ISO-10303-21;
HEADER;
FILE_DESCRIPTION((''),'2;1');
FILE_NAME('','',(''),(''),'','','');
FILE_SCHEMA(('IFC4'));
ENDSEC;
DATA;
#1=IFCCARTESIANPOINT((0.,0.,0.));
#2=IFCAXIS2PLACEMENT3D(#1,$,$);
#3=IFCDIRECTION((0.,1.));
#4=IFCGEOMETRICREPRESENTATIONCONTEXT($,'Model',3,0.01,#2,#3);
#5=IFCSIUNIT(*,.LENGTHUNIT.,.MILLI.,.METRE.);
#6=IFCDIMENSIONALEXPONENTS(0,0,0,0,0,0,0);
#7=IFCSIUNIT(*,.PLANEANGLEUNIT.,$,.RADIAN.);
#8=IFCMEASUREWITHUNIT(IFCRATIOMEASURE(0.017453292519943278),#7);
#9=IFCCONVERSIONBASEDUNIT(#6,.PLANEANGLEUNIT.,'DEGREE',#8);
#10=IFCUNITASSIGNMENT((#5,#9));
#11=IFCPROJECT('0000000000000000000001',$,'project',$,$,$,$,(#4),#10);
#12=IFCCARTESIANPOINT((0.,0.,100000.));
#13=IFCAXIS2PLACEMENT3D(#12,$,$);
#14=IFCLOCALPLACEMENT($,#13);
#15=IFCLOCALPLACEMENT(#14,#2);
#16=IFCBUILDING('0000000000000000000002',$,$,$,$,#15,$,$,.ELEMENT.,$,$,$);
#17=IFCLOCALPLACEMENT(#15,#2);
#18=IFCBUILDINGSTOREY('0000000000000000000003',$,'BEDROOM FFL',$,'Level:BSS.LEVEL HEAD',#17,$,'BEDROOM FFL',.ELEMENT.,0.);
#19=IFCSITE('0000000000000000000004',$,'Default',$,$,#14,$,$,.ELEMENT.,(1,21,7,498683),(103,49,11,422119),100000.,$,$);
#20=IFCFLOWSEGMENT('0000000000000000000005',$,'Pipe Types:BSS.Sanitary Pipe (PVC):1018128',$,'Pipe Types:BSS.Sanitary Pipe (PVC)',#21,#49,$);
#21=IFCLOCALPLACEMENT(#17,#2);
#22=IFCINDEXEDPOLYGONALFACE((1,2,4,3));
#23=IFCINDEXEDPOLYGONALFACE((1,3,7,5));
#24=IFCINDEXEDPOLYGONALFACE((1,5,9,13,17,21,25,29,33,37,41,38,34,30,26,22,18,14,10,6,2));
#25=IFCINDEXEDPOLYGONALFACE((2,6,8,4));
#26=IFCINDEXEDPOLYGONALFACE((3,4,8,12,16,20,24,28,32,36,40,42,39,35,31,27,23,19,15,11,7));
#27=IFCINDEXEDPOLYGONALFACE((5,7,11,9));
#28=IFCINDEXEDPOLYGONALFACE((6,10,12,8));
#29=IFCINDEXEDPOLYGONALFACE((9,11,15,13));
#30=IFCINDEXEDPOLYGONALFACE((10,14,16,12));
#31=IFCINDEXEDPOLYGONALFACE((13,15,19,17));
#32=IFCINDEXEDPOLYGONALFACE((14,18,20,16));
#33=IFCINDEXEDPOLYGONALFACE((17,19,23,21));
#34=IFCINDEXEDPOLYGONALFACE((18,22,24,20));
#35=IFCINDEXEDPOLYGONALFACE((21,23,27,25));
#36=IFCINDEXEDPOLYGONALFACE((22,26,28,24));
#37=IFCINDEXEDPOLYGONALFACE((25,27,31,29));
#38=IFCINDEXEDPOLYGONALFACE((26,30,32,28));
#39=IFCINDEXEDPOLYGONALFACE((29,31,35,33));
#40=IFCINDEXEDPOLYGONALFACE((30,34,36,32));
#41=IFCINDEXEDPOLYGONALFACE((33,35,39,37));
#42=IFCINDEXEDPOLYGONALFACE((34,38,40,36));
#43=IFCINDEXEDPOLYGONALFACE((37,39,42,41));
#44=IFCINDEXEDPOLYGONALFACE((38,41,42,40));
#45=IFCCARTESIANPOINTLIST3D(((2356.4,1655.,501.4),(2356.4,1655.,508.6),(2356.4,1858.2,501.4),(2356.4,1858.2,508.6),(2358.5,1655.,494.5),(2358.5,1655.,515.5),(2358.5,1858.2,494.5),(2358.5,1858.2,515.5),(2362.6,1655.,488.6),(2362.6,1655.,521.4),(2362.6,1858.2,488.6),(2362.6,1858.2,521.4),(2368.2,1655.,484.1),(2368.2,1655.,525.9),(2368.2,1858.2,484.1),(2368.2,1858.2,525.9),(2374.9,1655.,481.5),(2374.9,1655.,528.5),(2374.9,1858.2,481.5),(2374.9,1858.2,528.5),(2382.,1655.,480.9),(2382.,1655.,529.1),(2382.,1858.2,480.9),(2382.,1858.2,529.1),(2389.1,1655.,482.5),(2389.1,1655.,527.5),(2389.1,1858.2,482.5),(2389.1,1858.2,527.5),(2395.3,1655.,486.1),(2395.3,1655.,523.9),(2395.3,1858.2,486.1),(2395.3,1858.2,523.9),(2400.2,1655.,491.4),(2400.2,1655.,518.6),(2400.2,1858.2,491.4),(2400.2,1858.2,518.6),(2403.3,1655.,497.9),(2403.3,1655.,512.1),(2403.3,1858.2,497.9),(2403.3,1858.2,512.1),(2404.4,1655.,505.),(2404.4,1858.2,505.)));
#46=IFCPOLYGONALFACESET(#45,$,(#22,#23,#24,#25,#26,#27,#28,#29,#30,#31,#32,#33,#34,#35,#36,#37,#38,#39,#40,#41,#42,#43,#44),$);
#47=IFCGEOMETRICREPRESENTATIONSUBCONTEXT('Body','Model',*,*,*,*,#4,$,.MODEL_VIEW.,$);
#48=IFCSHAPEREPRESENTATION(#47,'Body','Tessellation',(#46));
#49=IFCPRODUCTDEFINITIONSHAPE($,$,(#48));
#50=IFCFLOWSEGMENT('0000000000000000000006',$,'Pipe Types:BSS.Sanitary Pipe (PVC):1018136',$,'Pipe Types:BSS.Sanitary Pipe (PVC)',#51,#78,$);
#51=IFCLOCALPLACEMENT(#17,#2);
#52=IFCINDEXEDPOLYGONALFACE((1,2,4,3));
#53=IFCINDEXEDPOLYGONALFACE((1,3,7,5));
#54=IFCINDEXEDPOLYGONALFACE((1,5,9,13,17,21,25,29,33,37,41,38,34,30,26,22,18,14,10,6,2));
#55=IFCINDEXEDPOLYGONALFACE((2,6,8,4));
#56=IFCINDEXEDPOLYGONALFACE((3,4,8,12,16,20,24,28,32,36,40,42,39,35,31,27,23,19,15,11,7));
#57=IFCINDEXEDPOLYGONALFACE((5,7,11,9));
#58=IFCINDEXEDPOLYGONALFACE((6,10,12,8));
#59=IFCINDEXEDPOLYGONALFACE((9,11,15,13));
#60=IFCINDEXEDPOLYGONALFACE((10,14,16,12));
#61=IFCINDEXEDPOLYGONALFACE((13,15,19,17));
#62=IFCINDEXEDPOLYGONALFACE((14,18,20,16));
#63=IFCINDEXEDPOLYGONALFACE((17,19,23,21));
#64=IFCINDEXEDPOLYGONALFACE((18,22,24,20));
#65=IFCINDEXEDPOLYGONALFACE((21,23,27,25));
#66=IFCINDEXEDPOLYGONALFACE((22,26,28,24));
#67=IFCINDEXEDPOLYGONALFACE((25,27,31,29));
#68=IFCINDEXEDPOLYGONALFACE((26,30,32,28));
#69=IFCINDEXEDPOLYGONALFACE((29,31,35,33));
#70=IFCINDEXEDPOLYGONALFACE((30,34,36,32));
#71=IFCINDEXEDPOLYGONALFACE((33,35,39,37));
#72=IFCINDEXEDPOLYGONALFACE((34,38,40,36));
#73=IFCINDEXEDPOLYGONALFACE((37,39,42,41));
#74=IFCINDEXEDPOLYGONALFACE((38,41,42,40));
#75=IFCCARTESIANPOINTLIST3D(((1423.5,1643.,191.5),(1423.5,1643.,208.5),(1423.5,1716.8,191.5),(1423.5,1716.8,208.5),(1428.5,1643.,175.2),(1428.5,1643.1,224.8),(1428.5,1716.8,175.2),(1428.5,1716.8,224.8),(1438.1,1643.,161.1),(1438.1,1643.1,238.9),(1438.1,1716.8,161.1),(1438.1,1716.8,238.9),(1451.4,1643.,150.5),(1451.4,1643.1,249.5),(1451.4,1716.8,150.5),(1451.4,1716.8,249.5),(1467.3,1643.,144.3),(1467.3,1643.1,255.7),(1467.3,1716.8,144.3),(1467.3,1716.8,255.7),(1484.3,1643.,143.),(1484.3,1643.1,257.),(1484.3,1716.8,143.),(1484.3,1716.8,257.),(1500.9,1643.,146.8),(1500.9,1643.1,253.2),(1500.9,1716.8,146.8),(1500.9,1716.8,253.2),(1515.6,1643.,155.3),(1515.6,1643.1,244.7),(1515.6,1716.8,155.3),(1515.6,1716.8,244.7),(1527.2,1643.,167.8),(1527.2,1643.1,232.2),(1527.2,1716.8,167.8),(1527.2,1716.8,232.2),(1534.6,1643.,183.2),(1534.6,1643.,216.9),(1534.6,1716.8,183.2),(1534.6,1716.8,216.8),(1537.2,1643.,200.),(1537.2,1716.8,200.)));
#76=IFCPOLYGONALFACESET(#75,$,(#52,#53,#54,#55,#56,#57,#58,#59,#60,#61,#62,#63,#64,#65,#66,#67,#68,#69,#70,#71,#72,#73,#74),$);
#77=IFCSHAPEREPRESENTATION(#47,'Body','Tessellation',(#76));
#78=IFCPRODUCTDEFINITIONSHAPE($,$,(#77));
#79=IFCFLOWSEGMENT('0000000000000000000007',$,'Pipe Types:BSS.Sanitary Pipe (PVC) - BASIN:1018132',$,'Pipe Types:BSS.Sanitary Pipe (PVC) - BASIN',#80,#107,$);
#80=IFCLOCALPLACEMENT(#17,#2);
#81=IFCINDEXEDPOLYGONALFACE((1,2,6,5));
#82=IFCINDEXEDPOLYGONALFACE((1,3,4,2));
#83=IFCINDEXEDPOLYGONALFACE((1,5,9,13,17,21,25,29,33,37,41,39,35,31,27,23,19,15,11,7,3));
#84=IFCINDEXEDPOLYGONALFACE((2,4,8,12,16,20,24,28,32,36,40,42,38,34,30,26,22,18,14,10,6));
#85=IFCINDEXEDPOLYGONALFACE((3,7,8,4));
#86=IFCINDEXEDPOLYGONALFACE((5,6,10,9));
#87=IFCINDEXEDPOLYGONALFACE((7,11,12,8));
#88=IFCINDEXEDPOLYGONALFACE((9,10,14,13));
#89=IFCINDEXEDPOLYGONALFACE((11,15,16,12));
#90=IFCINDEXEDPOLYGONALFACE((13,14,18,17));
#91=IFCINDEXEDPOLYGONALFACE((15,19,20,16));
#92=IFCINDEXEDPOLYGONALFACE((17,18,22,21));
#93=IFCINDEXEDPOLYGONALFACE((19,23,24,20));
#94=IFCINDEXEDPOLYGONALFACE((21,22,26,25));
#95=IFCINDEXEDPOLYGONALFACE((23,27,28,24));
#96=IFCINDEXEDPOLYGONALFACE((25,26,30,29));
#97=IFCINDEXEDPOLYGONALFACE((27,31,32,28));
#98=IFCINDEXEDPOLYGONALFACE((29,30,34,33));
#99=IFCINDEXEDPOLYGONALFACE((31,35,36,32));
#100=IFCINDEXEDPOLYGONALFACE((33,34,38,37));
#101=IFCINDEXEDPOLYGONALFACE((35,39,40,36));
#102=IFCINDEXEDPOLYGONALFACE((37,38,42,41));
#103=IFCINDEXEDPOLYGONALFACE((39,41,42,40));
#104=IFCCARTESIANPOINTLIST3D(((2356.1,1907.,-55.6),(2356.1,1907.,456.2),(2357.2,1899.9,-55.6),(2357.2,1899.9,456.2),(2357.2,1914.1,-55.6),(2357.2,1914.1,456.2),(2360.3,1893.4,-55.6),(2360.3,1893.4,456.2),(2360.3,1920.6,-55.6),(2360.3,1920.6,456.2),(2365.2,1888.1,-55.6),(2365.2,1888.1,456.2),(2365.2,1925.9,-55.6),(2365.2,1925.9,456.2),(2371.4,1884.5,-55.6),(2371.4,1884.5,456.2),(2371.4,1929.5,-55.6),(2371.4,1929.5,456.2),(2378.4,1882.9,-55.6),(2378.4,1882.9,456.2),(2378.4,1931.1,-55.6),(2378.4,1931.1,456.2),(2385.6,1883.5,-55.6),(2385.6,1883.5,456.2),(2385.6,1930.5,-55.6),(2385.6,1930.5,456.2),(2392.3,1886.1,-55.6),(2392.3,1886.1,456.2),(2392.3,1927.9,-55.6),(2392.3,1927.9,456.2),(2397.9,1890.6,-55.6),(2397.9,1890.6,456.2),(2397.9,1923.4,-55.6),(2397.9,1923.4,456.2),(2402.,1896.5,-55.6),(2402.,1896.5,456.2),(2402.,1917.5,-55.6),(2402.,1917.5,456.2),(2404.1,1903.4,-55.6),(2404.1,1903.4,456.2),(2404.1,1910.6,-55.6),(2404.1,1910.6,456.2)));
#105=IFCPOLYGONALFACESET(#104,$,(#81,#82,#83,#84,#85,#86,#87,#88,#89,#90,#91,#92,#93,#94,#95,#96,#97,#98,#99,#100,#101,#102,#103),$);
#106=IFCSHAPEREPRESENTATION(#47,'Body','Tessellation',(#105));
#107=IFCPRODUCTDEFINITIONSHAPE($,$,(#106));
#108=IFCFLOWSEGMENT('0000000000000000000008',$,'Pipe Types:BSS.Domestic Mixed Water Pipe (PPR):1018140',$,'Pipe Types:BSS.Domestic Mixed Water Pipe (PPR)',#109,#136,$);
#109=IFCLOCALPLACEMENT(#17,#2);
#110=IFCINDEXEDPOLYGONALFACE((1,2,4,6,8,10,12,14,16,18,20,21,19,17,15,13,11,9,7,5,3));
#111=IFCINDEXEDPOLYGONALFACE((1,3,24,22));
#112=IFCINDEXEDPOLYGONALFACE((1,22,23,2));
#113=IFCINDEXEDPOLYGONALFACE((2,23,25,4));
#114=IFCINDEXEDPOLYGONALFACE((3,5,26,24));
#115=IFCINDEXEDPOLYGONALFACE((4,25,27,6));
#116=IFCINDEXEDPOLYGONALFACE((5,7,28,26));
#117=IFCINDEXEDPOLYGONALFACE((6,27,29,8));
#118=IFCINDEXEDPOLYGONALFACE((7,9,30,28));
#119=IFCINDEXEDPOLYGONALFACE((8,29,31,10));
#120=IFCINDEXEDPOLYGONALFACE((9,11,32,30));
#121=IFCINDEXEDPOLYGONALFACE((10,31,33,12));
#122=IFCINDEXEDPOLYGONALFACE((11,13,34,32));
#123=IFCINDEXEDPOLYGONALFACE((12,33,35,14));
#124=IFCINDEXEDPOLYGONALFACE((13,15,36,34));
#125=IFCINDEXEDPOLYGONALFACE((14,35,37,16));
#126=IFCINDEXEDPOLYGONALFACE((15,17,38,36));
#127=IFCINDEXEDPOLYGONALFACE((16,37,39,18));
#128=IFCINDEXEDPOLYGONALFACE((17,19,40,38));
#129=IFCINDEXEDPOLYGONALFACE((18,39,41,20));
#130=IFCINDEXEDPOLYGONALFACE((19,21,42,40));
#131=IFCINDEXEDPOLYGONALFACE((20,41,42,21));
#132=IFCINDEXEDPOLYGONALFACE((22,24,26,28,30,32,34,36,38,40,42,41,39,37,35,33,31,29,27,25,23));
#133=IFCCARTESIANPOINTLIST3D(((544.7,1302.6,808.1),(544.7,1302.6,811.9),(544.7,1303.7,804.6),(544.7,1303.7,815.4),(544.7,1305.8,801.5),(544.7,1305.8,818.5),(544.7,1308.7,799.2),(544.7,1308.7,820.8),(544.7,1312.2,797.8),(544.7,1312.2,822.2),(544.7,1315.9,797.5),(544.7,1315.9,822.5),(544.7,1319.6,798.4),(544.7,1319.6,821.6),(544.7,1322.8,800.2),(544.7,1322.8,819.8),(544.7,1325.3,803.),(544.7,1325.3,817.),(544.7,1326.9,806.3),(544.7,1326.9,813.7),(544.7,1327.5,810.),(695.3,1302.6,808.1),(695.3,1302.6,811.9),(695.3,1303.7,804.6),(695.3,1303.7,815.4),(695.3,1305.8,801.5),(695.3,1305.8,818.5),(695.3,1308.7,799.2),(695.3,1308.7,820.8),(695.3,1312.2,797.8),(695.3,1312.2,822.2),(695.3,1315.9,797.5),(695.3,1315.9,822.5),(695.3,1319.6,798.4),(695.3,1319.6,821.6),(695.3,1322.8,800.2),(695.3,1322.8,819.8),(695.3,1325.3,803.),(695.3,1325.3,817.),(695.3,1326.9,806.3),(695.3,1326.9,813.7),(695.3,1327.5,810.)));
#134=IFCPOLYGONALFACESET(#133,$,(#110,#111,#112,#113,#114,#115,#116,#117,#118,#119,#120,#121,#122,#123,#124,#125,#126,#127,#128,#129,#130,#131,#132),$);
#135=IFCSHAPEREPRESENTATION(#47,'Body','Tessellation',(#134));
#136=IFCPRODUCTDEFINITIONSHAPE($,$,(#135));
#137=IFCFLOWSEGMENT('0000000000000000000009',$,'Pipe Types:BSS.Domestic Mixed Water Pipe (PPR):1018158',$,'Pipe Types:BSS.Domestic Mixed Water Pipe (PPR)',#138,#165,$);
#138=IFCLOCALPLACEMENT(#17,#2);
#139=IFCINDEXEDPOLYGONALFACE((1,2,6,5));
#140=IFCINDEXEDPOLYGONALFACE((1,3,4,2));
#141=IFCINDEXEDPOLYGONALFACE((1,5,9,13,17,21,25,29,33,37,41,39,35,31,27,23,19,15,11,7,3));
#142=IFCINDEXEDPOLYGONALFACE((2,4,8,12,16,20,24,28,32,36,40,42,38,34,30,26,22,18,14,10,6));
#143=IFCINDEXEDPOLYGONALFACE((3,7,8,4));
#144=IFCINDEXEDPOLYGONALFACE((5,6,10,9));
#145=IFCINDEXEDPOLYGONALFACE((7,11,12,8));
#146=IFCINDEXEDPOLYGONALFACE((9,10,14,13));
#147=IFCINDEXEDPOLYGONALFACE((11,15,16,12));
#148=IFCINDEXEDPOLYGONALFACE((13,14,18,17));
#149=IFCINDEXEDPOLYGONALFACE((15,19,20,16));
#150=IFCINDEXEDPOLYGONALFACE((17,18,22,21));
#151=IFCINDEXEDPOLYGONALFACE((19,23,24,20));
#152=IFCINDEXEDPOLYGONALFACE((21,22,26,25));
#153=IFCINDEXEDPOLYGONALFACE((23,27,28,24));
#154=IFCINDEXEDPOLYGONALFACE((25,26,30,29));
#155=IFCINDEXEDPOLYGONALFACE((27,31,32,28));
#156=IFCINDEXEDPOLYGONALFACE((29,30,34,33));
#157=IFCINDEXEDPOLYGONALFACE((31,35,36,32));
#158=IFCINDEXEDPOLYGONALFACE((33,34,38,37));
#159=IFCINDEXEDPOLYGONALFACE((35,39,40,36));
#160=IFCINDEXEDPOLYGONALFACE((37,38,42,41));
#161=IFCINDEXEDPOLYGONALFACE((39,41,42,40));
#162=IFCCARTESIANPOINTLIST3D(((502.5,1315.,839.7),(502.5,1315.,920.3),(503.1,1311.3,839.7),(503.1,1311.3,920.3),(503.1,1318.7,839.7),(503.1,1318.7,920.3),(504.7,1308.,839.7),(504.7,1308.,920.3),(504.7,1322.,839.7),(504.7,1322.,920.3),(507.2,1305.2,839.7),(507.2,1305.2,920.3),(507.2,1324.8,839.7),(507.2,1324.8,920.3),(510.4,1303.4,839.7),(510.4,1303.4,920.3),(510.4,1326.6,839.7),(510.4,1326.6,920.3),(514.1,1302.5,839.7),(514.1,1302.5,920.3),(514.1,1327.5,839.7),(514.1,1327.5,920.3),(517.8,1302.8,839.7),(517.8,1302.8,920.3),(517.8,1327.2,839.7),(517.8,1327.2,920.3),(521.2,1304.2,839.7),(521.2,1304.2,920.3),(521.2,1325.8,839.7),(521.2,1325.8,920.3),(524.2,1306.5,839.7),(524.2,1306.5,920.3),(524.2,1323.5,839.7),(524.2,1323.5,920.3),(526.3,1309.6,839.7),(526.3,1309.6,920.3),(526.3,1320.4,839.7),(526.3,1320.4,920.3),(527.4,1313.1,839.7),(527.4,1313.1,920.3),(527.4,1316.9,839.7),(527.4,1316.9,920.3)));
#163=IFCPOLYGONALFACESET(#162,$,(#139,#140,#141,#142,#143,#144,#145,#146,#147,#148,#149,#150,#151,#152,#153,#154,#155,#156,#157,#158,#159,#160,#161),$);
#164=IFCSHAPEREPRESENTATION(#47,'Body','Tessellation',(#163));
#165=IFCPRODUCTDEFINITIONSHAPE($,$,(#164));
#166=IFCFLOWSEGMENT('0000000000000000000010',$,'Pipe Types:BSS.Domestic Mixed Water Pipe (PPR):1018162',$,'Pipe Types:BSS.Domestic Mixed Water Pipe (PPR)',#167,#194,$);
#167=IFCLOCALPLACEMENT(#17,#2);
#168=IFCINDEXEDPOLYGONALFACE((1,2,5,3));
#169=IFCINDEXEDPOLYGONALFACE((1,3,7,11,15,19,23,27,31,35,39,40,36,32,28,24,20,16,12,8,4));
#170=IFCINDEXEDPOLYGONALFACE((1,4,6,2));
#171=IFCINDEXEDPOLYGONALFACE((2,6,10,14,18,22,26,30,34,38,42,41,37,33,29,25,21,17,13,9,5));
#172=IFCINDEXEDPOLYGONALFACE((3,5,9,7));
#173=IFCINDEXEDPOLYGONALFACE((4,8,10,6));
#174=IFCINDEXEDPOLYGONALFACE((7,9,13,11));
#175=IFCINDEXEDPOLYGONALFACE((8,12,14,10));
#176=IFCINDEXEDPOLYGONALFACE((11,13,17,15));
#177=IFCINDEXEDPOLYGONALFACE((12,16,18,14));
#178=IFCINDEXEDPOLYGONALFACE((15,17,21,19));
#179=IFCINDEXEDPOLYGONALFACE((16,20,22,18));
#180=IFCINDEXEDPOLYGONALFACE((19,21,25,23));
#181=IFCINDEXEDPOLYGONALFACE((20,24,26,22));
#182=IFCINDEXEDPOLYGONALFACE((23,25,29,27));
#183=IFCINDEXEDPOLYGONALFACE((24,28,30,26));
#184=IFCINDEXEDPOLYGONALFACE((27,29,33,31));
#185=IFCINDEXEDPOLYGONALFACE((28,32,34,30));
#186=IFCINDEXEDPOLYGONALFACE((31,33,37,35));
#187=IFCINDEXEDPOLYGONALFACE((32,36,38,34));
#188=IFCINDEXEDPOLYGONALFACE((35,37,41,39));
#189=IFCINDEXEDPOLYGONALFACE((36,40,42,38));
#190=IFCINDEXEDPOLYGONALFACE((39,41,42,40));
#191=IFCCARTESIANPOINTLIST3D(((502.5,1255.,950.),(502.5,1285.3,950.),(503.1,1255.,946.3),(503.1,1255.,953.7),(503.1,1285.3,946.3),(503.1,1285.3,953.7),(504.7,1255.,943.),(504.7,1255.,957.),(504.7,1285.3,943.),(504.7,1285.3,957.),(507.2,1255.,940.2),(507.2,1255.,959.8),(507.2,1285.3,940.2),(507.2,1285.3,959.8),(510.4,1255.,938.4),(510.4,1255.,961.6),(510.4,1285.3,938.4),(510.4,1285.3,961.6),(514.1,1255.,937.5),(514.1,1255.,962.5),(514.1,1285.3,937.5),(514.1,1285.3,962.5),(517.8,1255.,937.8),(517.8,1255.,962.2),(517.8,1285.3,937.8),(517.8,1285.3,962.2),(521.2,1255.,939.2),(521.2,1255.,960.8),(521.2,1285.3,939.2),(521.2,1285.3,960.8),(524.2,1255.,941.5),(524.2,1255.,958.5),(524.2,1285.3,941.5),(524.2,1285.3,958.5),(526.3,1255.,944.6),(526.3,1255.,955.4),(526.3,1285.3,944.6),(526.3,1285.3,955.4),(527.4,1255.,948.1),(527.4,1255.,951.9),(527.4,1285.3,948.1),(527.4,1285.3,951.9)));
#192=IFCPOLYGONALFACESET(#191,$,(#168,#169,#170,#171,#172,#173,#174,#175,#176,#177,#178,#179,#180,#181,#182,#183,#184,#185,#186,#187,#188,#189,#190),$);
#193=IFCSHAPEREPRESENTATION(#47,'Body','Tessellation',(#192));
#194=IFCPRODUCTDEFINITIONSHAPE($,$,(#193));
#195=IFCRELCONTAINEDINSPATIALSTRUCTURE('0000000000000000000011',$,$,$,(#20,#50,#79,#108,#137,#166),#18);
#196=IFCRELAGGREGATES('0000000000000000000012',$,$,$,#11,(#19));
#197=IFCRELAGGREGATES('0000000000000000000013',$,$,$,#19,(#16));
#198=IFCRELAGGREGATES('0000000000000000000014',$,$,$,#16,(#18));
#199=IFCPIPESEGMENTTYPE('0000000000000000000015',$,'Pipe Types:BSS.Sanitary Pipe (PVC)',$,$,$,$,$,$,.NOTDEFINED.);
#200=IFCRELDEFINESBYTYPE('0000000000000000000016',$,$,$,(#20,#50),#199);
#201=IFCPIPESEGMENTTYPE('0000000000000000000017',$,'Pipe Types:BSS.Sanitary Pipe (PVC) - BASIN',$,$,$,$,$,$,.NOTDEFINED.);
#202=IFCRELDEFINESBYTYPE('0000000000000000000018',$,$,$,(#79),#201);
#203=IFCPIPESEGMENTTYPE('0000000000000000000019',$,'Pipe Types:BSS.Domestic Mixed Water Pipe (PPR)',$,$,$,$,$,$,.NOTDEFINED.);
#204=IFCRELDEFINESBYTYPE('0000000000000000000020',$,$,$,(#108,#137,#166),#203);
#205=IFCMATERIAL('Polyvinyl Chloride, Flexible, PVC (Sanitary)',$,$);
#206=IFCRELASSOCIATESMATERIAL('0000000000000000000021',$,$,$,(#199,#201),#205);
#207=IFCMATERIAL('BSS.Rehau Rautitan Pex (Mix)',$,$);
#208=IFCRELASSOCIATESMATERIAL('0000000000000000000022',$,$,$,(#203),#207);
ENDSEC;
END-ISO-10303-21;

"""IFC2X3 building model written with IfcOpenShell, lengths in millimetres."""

from ifc_helpers import new_model, entity, si_unit, converted_unit, direction, frame, frame_2d, origin, origin_2d_with_axis, place, context, subcontext, project, spatial, circle, extrude, material, type_object, element, save


model = new_model("IFC2X3")

# Units and contexts
model_context = context("Model", 3, precision=0.01, world=origin(), true_north=direction((0.0, 1.0)))
body_context = subcontext(model_context, "Body", "Model", "MODEL_VIEW")
ifc_project = project(units=[si_unit("LENGTHUNIT", "METRE", prefix="MILLI"), converted_unit("PLANEANGLEUNIT", "DEGREE", entity("IfcRatioMeasure", 0.017453292519943278), si_unit("PLANEANGLEUNIT", "RADIAN"), dimensions=[0, 0, 0, 0, 0, 0, 0])], contexts=[model_context])

# Site, building, storey
site_placement = place(None, frame((0.0, 0.0, 100000.0)))
site = spatial("IfcSite", under=ifc_project, at=site_placement, Name="Default", CompositionType="ELEMENT", RefLatitude=(1, 21, 7, 498683), RefLongitude=(103, 49, 11, 422119), RefElevation=100000.0)
building_placement = place(site_placement, origin())
building = spatial("IfcBuilding", under=site, at=building_placement, CompositionType="ELEMENT")
storey_placement = place(building_placement, origin())
storey = spatial("IfcBuildingStorey", under=building, at=storey_placement, Name="BEDROOM FFL", ObjectType="Level:BSS.LEVEL HEAD", LongName="BEDROOM FFL", CompositionType="ELEMENT", Elevation=0.0)

# Flow segments
ifc_material_1 = material(Name="Polyvinyl Chloride, Flexible, PVC (Sanitary)")
pipe_segment_type_1 = type_object("IfcPipeSegmentType", Name="Pipe Types:BSS.Sanitary Pipe (PVC)", PredefinedType="NOTDEFINED", material=ifc_material_1)
flow_segment_1_placement = place(storey_placement, origin())
element("IfcFlowSegment", 1, at=flow_segment_1_placement, inside=storey, type_object=pipe_segment_type_1, Name="Pipe Types:BSS.Sanitary Pipe (PVC):1018128", ObjectType="Pipe Types:BSS.Sanitary Pipe (PVC)", context=body_context, shape_type="SweptSolid", body=[
    extrude(circle(Radius=24.1, at=origin_2d_with_axis()), frame((2380.2, 1655.0, 505.0), z_axis=(0.0, 1.0, 0.0), x_axis=(1.0, 0.0, 0.0)), (0.0, 0.0, 1.0), 203.2),
])
flow_segment_2_placement = place(storey_placement, origin())
element("IfcFlowSegment", 2, at=flow_segment_2_placement, inside=storey, type_object=pipe_segment_type_1, Name="Pipe Types:BSS.Sanitary Pipe (PVC):1018136", ObjectType="Pipe Types:BSS.Sanitary Pipe (PVC)", context=body_context, shape_type="SweptSolid", body=[
    extrude(circle(Radius=57.2, at=frame_2d((0.0, 0.0), x_axis=(1.0, 0.0))), frame((1480.0, 1716.8, 200.0), z_axis=(0.0, -1.0, 0.000211), x_axis=(1.0, 0.0, 0.0)), (0.0, 0.0, 1.0), 73.8),
])
pipe_segment_type_2 = type_object("IfcPipeSegmentType", Name="Pipe Types:BSS.Sanitary Pipe (PVC) - BASIN", PredefinedType="NOTDEFINED", material=ifc_material_1)
flow_segment_3_placement = place(storey_placement, origin())
element("IfcFlowSegment", 3, at=flow_segment_3_placement, inside=storey, type_object=pipe_segment_type_2, Name="Pipe Types:BSS.Sanitary Pipe (PVC) - BASIN:1018132", ObjectType="Pipe Types:BSS.Sanitary Pipe (PVC) - BASIN", context=body_context, shape_type="SweptSolid", body=[
    extrude(circle(Radius=24.1, at=frame_2d((0.0, 0.0), x_axis=(1.0, 0.0))), frame((2380.2, 1907.0, -55.6), z_axis=(0.0, 0.0, 1.0), x_axis=(-1.0, 0.0, 0.0)), (0.0, 0.0, 1.0), 511.8),
])
ifc_material_2 = material(Name="BSS.Rehau Rautitan Pex (Mix)")
pipe_segment_type_3 = type_object("IfcPipeSegmentType", Name="Pipe Types:BSS.Domestic Mixed Water Pipe (PPR)", PredefinedType="NOTDEFINED", material=ifc_material_2)
flow_segment_4_placement = place(storey_placement, origin())
element("IfcFlowSegment", 4, at=flow_segment_4_placement, inside=storey, type_object=pipe_segment_type_3, Name="Pipe Types:BSS.Domestic Mixed Water Pipe (PPR):1018140", ObjectType="Pipe Types:BSS.Domestic Mixed Water Pipe (PPR)", context=body_context, shape_type="SweptSolid", body=[
    extrude(circle(Radius=12.5, at=frame_2d((0.0, 0.0), x_axis=(1.0, 0.0))), frame((544.7, 1315.0, 810.0), z_axis=(1.0, 0.0, 0.0), x_axis=(0.0, 1.0, 0.0)), (0.0, 0.0, 1.0), 150.6),
])
flow_segment_5_placement = place(storey_placement, origin())
element("IfcFlowSegment", 5, at=flow_segment_5_placement, inside=storey, type_object=pipe_segment_type_3, Name="Pipe Types:BSS.Domestic Mixed Water Pipe (PPR):1018158", ObjectType="Pipe Types:BSS.Domestic Mixed Water Pipe (PPR)", context=body_context, shape_type="SweptSolid", body=[
    extrude(circle(Radius=12.5, at=origin_2d_with_axis()), frame((515.0, 1315.0, 839.7), z_axis=(0.0, 0.0, 1.0), x_axis=(-1.0, 0.0, 0.0)), (0.0, 0.0, 1.0), 80.6),
])
flow_segment_6_placement = place(storey_placement, origin())
element("IfcFlowSegment", 6, at=flow_segment_6_placement, inside=storey, type_object=pipe_segment_type_3, Name="Pipe Types:BSS.Domestic Mixed Water Pipe (PPR):1018162", ObjectType="Pipe Types:BSS.Domestic Mixed Water Pipe (PPR)", context=body_context, shape_type="SweptSolid", body=[
    extrude(circle(Radius=12.5, at=frame_2d((0.0, 0.0), x_axis=(1.0, 0.0))), frame((515.0, 1255.0, 950.0), z_axis=(0.0, 1.0, 0.0), x_axis=(-1.0, 0.0, 0.0)), (0.0, 0.0, 1.0), 30.3),
])

save(model, "model.ifc")
